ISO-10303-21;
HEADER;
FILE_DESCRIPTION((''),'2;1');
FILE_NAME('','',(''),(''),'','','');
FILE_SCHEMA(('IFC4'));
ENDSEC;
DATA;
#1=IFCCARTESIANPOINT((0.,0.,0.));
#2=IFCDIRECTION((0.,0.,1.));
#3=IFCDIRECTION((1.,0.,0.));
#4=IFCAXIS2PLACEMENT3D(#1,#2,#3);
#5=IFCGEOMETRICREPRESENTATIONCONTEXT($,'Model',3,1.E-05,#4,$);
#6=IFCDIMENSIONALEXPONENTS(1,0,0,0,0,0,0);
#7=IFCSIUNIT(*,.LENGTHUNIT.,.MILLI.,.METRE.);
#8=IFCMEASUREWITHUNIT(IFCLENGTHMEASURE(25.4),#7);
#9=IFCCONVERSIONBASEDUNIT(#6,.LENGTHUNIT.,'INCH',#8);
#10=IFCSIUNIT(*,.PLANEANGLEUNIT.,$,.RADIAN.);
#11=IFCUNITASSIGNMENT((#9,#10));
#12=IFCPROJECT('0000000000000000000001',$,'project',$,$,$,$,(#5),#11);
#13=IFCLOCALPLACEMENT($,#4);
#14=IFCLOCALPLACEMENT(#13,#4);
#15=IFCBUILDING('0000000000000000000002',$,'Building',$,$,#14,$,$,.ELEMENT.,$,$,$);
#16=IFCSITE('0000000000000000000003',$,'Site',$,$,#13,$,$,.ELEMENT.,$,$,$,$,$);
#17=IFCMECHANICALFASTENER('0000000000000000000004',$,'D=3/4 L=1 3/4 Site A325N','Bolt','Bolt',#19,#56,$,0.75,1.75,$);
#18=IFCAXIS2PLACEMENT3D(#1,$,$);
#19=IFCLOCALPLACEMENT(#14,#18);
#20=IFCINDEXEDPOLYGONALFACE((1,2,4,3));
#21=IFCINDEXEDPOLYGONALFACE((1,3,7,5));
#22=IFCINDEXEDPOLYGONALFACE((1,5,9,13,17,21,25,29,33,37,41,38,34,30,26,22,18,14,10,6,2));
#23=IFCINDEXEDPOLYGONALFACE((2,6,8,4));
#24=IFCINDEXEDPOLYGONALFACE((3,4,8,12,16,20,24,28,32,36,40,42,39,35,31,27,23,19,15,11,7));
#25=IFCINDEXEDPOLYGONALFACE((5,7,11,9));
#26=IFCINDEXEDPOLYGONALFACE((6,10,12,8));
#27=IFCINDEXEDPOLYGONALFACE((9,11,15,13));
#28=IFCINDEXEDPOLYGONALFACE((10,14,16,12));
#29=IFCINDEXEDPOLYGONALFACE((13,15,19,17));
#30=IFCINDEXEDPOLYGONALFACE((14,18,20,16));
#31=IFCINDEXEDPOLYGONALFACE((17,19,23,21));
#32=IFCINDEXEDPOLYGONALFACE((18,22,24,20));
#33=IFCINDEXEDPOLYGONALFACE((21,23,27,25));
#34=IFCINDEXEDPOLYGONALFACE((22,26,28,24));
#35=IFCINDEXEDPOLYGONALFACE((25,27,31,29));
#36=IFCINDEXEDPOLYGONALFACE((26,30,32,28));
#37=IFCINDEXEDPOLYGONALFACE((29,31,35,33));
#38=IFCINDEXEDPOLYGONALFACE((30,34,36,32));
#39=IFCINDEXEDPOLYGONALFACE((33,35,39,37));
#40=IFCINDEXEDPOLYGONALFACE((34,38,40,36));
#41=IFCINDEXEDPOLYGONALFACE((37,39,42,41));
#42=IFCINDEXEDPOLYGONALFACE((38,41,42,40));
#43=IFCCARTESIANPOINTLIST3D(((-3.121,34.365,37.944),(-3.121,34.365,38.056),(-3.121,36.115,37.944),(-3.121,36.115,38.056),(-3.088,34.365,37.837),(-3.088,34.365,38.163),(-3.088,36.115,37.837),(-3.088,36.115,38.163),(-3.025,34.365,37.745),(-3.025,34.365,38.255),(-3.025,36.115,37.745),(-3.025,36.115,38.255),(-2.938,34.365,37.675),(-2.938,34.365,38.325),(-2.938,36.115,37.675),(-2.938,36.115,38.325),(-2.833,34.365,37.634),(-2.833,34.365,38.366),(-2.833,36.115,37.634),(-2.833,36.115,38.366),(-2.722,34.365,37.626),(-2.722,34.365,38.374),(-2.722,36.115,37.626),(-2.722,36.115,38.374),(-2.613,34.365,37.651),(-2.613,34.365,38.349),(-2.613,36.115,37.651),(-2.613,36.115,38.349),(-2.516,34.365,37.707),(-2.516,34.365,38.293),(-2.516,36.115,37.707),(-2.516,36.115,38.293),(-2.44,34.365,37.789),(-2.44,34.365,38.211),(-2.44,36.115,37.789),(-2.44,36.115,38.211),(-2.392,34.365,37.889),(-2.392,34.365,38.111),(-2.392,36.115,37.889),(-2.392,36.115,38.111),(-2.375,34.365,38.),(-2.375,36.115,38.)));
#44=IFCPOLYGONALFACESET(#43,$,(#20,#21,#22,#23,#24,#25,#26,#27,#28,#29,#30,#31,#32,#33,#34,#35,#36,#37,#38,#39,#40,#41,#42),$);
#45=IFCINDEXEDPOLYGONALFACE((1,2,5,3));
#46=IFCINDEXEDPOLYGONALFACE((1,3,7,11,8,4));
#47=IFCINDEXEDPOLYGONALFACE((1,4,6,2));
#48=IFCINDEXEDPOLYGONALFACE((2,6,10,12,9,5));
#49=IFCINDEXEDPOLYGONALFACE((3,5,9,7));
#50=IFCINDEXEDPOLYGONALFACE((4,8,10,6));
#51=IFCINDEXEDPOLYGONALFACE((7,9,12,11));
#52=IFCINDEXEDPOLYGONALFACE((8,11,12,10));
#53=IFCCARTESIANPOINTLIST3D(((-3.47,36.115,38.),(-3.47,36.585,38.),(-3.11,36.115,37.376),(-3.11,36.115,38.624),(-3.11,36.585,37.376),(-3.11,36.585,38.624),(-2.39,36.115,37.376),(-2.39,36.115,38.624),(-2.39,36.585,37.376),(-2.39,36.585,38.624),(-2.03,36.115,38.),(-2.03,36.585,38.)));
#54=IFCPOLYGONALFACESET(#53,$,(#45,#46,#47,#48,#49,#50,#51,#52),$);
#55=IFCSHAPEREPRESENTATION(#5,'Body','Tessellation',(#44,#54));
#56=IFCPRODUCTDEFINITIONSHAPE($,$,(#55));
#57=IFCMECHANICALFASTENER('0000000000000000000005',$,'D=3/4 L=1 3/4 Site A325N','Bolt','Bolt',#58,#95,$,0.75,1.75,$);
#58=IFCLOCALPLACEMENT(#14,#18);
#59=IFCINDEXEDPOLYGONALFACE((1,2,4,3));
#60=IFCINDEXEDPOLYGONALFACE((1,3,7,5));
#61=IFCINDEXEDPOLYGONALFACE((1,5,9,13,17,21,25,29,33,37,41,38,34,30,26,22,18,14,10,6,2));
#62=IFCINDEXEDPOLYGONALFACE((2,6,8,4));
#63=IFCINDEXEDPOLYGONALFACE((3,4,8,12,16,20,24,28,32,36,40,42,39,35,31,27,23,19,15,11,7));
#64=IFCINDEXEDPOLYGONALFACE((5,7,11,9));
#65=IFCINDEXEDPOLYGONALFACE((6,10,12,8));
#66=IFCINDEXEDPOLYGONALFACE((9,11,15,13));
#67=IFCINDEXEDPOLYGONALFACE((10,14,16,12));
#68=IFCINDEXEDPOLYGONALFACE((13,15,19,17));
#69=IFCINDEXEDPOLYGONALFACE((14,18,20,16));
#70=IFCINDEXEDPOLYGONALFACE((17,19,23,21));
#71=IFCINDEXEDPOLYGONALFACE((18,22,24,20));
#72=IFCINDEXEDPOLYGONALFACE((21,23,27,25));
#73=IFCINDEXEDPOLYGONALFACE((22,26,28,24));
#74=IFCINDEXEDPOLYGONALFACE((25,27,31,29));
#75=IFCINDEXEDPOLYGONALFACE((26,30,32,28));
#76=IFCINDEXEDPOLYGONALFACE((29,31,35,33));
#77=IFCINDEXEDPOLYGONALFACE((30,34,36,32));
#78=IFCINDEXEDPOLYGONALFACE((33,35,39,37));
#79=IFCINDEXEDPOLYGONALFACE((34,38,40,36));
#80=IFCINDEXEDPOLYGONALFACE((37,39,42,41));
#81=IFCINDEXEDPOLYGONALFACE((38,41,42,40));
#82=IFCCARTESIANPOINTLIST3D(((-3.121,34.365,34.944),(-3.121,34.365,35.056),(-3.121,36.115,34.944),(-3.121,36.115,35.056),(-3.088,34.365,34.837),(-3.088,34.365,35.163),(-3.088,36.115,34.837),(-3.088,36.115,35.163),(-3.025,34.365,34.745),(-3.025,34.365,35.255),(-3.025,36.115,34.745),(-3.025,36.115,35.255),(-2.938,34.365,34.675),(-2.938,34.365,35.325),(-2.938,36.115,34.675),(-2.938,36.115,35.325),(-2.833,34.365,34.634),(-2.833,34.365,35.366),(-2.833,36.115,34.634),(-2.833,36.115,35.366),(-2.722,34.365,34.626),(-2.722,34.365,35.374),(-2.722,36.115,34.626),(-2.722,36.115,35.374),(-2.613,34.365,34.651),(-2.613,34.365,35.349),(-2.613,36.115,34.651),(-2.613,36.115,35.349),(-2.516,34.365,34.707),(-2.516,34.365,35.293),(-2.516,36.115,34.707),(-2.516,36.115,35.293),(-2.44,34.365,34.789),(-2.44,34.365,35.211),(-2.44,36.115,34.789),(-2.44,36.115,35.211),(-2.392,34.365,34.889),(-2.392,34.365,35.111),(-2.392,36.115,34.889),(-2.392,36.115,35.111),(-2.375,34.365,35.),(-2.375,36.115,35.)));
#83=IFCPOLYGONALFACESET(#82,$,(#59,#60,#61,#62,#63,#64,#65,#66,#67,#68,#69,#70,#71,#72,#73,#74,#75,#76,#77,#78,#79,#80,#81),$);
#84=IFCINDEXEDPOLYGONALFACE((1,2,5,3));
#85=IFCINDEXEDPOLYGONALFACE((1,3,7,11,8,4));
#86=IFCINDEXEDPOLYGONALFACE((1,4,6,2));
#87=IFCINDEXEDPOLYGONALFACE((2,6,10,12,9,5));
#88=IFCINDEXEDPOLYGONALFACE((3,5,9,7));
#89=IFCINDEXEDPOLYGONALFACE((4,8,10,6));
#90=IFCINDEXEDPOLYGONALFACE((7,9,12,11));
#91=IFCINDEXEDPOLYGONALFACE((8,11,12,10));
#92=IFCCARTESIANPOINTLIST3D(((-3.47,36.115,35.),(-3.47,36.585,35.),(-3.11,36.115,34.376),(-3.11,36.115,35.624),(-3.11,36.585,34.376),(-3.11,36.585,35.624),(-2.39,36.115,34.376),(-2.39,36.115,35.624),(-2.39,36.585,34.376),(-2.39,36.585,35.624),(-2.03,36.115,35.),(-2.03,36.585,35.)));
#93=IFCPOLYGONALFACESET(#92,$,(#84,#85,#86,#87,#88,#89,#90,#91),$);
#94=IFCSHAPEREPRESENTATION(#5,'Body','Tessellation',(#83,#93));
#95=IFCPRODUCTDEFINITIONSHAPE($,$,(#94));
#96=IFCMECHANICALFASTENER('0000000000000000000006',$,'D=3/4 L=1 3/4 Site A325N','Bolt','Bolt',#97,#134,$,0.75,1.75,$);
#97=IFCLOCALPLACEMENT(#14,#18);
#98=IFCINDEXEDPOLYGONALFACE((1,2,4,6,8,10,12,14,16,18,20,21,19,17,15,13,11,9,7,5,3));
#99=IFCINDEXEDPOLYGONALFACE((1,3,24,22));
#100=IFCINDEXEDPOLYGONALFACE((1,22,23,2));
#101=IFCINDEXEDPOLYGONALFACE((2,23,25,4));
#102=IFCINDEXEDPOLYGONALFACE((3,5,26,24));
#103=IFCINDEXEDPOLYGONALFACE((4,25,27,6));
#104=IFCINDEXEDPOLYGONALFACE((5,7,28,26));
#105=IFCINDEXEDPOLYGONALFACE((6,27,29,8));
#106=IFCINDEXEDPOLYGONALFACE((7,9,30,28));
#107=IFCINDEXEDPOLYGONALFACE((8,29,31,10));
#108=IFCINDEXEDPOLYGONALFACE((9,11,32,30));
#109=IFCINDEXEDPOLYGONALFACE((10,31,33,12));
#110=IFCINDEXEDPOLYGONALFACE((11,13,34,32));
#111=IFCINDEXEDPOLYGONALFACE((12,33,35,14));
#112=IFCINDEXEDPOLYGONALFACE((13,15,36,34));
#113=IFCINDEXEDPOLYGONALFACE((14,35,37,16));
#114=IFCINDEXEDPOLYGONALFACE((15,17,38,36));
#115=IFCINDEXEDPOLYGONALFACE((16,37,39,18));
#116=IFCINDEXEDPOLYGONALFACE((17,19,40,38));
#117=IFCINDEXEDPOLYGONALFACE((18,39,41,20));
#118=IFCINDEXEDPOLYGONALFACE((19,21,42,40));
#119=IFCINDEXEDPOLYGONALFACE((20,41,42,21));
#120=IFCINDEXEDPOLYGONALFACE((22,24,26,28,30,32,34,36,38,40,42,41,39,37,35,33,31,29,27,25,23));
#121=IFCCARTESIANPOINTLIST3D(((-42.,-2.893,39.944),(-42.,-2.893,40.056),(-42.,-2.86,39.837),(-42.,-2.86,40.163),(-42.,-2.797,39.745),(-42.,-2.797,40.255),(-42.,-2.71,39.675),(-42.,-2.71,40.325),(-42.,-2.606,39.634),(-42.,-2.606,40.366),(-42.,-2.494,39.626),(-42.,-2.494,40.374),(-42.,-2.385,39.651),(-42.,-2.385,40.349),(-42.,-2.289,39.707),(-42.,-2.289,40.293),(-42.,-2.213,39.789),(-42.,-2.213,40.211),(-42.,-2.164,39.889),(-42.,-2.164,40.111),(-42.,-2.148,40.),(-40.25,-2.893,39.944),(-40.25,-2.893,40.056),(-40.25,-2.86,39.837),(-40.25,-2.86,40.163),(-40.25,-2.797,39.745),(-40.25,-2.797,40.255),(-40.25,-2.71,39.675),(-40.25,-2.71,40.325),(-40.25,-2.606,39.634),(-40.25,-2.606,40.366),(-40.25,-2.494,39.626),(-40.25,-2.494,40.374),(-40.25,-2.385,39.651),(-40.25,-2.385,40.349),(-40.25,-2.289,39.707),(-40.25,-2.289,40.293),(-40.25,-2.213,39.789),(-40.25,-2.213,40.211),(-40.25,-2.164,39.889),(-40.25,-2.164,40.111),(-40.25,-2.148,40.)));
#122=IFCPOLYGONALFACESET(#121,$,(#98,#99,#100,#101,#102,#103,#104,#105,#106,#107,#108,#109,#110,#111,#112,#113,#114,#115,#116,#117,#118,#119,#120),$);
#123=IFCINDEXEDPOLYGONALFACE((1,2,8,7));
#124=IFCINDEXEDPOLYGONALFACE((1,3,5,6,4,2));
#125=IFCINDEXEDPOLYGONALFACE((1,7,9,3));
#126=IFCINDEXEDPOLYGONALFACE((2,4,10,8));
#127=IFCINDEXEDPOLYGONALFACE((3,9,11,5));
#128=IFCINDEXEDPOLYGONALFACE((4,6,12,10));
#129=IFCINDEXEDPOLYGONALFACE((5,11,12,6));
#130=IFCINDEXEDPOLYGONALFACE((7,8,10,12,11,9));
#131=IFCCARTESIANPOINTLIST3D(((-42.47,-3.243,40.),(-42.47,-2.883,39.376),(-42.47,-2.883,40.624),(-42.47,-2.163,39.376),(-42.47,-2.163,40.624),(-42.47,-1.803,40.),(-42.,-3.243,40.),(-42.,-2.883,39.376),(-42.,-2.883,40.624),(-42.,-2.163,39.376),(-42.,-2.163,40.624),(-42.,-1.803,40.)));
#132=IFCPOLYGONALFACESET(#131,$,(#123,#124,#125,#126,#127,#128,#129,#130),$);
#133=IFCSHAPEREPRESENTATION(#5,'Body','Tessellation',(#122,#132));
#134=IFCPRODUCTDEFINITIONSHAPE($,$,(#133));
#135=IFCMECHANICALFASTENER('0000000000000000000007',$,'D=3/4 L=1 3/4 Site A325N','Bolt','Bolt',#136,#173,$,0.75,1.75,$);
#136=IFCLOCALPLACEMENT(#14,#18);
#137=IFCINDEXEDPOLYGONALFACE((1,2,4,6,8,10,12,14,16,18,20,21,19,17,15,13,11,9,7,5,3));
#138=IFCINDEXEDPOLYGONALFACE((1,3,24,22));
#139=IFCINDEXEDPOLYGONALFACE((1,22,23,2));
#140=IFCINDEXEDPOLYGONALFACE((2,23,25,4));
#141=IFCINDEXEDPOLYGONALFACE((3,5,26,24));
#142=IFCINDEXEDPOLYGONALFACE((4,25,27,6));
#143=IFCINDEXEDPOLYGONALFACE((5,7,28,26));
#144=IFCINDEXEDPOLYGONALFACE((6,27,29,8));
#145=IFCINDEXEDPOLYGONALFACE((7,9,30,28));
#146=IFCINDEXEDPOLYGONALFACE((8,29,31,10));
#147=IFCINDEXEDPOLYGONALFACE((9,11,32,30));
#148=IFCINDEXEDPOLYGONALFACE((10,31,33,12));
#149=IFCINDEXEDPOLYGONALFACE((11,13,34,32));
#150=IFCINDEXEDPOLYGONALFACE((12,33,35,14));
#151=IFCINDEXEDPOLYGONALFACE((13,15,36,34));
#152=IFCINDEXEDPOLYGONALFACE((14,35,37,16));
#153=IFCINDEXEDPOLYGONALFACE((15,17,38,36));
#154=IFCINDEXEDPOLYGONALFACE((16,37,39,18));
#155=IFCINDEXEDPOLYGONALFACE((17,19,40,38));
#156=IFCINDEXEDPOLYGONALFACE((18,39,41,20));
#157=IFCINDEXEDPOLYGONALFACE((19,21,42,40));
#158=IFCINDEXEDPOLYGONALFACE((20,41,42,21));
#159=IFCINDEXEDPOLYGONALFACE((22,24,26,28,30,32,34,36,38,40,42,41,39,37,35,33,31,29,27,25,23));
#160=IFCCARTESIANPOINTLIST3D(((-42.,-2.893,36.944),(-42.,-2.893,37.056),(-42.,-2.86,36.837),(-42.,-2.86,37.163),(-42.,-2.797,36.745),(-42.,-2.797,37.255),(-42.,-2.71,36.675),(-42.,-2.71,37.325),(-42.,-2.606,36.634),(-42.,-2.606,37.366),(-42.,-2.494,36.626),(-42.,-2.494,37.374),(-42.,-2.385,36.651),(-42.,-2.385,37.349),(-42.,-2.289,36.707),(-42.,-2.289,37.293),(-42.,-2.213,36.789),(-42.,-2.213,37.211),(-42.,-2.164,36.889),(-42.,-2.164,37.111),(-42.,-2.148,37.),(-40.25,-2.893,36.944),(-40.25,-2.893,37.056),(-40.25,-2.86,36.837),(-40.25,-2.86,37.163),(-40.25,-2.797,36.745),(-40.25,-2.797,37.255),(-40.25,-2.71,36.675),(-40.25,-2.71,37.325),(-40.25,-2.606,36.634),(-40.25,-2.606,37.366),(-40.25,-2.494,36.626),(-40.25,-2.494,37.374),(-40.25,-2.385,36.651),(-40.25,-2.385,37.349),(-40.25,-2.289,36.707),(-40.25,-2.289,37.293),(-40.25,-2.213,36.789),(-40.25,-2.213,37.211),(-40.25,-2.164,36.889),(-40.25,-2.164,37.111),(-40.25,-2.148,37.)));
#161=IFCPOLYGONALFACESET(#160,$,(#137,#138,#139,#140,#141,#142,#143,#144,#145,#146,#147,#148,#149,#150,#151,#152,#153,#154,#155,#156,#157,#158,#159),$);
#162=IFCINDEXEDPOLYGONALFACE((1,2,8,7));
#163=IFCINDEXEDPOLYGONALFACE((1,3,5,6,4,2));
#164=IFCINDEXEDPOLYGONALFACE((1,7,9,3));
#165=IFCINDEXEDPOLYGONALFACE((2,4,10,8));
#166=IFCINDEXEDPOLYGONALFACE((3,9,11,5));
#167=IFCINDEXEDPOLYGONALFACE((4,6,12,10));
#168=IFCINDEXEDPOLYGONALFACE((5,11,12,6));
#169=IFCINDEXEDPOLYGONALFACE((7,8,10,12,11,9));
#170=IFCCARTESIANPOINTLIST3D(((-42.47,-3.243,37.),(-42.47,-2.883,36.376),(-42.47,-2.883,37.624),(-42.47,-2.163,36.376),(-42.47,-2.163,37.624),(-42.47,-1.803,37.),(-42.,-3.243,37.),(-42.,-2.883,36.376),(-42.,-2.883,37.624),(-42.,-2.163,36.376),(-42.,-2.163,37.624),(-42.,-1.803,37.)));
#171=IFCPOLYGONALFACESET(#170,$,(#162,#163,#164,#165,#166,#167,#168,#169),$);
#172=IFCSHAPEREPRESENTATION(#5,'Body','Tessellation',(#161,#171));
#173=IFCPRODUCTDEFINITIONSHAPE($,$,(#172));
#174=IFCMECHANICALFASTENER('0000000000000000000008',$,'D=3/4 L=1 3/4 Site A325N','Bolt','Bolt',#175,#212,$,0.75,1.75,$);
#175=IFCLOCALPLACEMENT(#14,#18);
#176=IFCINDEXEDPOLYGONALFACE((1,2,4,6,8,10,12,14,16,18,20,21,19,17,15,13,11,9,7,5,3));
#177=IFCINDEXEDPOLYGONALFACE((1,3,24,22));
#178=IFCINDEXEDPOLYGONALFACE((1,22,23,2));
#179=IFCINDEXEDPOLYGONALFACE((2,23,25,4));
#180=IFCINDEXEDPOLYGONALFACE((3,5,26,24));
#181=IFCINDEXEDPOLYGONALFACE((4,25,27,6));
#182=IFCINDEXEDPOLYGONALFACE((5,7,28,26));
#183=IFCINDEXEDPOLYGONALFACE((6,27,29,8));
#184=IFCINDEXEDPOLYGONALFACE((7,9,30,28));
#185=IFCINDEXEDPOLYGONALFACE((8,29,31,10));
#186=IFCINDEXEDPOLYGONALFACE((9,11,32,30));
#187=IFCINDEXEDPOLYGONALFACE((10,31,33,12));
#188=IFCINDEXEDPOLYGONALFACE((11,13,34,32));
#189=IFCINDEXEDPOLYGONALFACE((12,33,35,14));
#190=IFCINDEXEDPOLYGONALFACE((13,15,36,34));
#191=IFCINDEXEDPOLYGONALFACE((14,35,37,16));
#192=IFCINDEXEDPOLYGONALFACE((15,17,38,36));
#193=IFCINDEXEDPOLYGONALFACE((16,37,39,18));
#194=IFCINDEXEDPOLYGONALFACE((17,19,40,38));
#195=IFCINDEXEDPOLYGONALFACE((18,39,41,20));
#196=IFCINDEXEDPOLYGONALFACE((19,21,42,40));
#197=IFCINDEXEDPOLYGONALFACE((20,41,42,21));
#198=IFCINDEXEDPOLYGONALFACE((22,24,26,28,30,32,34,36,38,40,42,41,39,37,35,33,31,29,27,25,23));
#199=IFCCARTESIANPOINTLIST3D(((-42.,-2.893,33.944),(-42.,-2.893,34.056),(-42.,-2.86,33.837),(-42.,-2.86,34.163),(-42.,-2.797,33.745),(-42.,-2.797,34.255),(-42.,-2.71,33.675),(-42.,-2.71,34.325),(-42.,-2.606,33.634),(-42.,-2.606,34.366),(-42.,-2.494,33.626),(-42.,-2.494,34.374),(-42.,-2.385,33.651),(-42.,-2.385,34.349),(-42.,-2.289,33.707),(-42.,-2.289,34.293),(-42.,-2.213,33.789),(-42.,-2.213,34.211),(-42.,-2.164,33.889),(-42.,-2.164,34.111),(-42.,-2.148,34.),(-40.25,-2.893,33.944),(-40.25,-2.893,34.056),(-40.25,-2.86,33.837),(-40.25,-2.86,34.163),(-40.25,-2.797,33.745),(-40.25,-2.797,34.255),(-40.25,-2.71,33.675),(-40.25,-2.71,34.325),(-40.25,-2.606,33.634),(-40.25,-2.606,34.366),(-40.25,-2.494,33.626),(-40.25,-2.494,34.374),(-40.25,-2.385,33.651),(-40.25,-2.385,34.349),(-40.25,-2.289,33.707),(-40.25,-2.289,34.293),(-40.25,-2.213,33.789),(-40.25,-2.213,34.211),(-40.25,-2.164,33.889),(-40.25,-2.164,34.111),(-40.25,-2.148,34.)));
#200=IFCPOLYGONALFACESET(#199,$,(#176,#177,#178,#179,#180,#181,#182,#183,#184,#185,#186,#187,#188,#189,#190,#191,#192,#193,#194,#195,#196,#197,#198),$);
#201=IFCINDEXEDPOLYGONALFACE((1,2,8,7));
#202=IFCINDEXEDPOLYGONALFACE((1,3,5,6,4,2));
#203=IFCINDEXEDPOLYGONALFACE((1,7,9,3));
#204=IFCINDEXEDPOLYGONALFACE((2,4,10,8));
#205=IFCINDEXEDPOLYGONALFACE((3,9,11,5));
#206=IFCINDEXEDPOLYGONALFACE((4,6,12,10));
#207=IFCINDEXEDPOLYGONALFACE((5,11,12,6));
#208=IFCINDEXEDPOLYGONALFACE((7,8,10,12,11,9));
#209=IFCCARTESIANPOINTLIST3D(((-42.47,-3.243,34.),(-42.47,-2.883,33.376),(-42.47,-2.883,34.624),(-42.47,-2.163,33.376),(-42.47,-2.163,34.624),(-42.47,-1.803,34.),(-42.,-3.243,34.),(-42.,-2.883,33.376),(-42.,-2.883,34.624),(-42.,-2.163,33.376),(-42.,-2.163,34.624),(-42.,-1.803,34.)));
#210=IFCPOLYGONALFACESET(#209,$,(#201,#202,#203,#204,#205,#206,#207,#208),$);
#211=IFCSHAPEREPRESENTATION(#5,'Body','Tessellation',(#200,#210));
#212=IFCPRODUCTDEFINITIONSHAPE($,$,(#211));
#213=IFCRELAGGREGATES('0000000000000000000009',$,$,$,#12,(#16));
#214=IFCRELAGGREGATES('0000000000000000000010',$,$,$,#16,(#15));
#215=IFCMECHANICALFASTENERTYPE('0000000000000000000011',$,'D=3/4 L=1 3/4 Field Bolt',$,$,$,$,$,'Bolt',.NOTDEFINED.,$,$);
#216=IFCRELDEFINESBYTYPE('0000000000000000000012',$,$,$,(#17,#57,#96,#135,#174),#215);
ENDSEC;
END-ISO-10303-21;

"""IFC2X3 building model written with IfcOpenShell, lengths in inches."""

from ifc_helpers import new_model, entity, si_unit, converted_unit, frame, origin_with_axes, origin_2d_with_axis, place, context, project, spatial, polyline, circle, outline, extrude, source, transform, mapped, type_object, type_shapes, element, save


model = new_model("IFC2X3")

# Units and contexts
model_context = context("Model", 3, precision=1e-05, world=origin_with_axes())
ifc_project = project(units=[converted_unit("LENGTHUNIT", "INCH", entity("IfcLengthMeasure", 25.4), si_unit("LENGTHUNIT", "METRE", prefix="MILLI"), dimensions=[1, 0, 0, 0, 0, 0, 0]), si_unit("PLANEANGLEUNIT", "RADIAN")], contexts=[model_context])

# Site, building
site_placement = place(None, origin_with_axes())
site = spatial("IfcSite", under=ifc_project, at=site_placement, Name="Site", CompositionType="ELEMENT")
building_placement = place(site_placement, origin_with_axes())
building = spatial("IfcBuilding", under=site, at=building_placement, Name="Building", CompositionType="ELEMENT")

# Mechanical fasteners
mechanical_fastener_type_1 = type_object("IfcMechanicalFastenerType", Name="D=3/4 L=1 3/4 Field Bolt", ElementType="Bolt")
shared_shape_1 = source(origin_with_axes(), model_context, "Body", "SweptSolid", [
    extrude(circle(Radius=0.375, at=origin_2d_with_axis()), frame((0.0, 0.0, 0.0), z_axis=(1.0, 0.0, 0.0), x_axis=(0.0, 1.0, 0.0)), (0.0, 0.0, 1.0), 1.75),
    extrude(outline(polyline([(-0.72, 0.0), (-0.36, 0.624), (0.36, 0.624), (0.72, 0.0), (0.36, -0.624), (-0.36, -0.624), (-0.72, 0.0)])), frame((0.0, 0.0, 0.0), z_axis=(1.0, 0.0, 0.0), x_axis=(0.0, 1.0, 0.0)), (0.0, 0.0, -1.0), 0.47),
])
type_shapes(mechanical_fastener_type_1, [shared_shape_1])
placement_1 = place(building_placement, frame((0.0, 36.0, 44.0), z_axis=(0.0, 0.0, 1.0), x_axis=(-1.0, 0.0, 0.0)))
placement_2 = place(placement_1, frame((2.75, -0.115, -9.0), z_axis=(0.0, 0.0, 1.0), x_axis=(0.0, 1.0, 0.0)))
for number, where, z_axis, x_axis, name in (
    (1, (0.0, 0.0, 3.0), (0.0, 0.0, 1.0), (1.0, 0.0, 0.0), "D=3/4 L=1 3/4 Site A325N"),
    (2, (0.0, 0.0, 0.0), (0.0, 0.0, 1.0), (1.0, 0.0, 0.0), "D=3/4 L=1 3/4 Site A325N"),
):
    element("IfcMechanicalFastener", number, at=place(placement_2, frame(where, z_axis=z_axis, x_axis=x_axis)), type_object=mechanical_fastener_type_1, Name=name, Description="Bolt", ObjectType="Bolt", NominalDiameter=0.75, NominalLength=1.75, context=model_context, shape_type="MappedRepresentation", body=[
        mapped(shared_shape_1, transform((0.0, 0.0, 0.0), scale=1.0)),
    ])
placement_3 = place(building_placement, frame((-42.0, 0.0, 43.0), z_axis=(0.0, 0.0, 1.0), x_axis=(0.0, -1.0, 0.0)))
placement_4 = place(placement_3, frame((2.523, 0.0, -9.0), z_axis=(0.0, 0.0, 1.0), x_axis=(0.0, 1.0, 0.0)))
for number, where, z_axis, x_axis, name in (
    (3, (0.0, 0.0, 6.0), (0.0, 0.0, 1.0), (1.0, 0.0, 0.0), "D=3/4 L=1 3/4 Site A325N"),
    (4, (0.0, 0.0, 3.0), (0.0, 0.0, 1.0), (1.0, 0.0, 0.0), "D=3/4 L=1 3/4 Site A325N"),
    (5, (0.0, 0.0, 0.0), (0.0, 0.0, 1.0), (1.0, 0.0, 0.0), "D=3/4 L=1 3/4 Site A325N"),
):
    element("IfcMechanicalFastener", number, at=place(placement_4, frame(where, z_axis=z_axis, x_axis=x_axis)), type_object=mechanical_fastener_type_1, Name=name, Description="Bolt", ObjectType="Bolt", NominalDiameter=0.75, NominalLength=1.75, context=model_context, shape_type="MappedRepresentation", body=[
        mapped(shared_shape_1, transform((0.0, 0.0, 0.0), scale=1.0)),
    ])

save(model, "model.ifc")
